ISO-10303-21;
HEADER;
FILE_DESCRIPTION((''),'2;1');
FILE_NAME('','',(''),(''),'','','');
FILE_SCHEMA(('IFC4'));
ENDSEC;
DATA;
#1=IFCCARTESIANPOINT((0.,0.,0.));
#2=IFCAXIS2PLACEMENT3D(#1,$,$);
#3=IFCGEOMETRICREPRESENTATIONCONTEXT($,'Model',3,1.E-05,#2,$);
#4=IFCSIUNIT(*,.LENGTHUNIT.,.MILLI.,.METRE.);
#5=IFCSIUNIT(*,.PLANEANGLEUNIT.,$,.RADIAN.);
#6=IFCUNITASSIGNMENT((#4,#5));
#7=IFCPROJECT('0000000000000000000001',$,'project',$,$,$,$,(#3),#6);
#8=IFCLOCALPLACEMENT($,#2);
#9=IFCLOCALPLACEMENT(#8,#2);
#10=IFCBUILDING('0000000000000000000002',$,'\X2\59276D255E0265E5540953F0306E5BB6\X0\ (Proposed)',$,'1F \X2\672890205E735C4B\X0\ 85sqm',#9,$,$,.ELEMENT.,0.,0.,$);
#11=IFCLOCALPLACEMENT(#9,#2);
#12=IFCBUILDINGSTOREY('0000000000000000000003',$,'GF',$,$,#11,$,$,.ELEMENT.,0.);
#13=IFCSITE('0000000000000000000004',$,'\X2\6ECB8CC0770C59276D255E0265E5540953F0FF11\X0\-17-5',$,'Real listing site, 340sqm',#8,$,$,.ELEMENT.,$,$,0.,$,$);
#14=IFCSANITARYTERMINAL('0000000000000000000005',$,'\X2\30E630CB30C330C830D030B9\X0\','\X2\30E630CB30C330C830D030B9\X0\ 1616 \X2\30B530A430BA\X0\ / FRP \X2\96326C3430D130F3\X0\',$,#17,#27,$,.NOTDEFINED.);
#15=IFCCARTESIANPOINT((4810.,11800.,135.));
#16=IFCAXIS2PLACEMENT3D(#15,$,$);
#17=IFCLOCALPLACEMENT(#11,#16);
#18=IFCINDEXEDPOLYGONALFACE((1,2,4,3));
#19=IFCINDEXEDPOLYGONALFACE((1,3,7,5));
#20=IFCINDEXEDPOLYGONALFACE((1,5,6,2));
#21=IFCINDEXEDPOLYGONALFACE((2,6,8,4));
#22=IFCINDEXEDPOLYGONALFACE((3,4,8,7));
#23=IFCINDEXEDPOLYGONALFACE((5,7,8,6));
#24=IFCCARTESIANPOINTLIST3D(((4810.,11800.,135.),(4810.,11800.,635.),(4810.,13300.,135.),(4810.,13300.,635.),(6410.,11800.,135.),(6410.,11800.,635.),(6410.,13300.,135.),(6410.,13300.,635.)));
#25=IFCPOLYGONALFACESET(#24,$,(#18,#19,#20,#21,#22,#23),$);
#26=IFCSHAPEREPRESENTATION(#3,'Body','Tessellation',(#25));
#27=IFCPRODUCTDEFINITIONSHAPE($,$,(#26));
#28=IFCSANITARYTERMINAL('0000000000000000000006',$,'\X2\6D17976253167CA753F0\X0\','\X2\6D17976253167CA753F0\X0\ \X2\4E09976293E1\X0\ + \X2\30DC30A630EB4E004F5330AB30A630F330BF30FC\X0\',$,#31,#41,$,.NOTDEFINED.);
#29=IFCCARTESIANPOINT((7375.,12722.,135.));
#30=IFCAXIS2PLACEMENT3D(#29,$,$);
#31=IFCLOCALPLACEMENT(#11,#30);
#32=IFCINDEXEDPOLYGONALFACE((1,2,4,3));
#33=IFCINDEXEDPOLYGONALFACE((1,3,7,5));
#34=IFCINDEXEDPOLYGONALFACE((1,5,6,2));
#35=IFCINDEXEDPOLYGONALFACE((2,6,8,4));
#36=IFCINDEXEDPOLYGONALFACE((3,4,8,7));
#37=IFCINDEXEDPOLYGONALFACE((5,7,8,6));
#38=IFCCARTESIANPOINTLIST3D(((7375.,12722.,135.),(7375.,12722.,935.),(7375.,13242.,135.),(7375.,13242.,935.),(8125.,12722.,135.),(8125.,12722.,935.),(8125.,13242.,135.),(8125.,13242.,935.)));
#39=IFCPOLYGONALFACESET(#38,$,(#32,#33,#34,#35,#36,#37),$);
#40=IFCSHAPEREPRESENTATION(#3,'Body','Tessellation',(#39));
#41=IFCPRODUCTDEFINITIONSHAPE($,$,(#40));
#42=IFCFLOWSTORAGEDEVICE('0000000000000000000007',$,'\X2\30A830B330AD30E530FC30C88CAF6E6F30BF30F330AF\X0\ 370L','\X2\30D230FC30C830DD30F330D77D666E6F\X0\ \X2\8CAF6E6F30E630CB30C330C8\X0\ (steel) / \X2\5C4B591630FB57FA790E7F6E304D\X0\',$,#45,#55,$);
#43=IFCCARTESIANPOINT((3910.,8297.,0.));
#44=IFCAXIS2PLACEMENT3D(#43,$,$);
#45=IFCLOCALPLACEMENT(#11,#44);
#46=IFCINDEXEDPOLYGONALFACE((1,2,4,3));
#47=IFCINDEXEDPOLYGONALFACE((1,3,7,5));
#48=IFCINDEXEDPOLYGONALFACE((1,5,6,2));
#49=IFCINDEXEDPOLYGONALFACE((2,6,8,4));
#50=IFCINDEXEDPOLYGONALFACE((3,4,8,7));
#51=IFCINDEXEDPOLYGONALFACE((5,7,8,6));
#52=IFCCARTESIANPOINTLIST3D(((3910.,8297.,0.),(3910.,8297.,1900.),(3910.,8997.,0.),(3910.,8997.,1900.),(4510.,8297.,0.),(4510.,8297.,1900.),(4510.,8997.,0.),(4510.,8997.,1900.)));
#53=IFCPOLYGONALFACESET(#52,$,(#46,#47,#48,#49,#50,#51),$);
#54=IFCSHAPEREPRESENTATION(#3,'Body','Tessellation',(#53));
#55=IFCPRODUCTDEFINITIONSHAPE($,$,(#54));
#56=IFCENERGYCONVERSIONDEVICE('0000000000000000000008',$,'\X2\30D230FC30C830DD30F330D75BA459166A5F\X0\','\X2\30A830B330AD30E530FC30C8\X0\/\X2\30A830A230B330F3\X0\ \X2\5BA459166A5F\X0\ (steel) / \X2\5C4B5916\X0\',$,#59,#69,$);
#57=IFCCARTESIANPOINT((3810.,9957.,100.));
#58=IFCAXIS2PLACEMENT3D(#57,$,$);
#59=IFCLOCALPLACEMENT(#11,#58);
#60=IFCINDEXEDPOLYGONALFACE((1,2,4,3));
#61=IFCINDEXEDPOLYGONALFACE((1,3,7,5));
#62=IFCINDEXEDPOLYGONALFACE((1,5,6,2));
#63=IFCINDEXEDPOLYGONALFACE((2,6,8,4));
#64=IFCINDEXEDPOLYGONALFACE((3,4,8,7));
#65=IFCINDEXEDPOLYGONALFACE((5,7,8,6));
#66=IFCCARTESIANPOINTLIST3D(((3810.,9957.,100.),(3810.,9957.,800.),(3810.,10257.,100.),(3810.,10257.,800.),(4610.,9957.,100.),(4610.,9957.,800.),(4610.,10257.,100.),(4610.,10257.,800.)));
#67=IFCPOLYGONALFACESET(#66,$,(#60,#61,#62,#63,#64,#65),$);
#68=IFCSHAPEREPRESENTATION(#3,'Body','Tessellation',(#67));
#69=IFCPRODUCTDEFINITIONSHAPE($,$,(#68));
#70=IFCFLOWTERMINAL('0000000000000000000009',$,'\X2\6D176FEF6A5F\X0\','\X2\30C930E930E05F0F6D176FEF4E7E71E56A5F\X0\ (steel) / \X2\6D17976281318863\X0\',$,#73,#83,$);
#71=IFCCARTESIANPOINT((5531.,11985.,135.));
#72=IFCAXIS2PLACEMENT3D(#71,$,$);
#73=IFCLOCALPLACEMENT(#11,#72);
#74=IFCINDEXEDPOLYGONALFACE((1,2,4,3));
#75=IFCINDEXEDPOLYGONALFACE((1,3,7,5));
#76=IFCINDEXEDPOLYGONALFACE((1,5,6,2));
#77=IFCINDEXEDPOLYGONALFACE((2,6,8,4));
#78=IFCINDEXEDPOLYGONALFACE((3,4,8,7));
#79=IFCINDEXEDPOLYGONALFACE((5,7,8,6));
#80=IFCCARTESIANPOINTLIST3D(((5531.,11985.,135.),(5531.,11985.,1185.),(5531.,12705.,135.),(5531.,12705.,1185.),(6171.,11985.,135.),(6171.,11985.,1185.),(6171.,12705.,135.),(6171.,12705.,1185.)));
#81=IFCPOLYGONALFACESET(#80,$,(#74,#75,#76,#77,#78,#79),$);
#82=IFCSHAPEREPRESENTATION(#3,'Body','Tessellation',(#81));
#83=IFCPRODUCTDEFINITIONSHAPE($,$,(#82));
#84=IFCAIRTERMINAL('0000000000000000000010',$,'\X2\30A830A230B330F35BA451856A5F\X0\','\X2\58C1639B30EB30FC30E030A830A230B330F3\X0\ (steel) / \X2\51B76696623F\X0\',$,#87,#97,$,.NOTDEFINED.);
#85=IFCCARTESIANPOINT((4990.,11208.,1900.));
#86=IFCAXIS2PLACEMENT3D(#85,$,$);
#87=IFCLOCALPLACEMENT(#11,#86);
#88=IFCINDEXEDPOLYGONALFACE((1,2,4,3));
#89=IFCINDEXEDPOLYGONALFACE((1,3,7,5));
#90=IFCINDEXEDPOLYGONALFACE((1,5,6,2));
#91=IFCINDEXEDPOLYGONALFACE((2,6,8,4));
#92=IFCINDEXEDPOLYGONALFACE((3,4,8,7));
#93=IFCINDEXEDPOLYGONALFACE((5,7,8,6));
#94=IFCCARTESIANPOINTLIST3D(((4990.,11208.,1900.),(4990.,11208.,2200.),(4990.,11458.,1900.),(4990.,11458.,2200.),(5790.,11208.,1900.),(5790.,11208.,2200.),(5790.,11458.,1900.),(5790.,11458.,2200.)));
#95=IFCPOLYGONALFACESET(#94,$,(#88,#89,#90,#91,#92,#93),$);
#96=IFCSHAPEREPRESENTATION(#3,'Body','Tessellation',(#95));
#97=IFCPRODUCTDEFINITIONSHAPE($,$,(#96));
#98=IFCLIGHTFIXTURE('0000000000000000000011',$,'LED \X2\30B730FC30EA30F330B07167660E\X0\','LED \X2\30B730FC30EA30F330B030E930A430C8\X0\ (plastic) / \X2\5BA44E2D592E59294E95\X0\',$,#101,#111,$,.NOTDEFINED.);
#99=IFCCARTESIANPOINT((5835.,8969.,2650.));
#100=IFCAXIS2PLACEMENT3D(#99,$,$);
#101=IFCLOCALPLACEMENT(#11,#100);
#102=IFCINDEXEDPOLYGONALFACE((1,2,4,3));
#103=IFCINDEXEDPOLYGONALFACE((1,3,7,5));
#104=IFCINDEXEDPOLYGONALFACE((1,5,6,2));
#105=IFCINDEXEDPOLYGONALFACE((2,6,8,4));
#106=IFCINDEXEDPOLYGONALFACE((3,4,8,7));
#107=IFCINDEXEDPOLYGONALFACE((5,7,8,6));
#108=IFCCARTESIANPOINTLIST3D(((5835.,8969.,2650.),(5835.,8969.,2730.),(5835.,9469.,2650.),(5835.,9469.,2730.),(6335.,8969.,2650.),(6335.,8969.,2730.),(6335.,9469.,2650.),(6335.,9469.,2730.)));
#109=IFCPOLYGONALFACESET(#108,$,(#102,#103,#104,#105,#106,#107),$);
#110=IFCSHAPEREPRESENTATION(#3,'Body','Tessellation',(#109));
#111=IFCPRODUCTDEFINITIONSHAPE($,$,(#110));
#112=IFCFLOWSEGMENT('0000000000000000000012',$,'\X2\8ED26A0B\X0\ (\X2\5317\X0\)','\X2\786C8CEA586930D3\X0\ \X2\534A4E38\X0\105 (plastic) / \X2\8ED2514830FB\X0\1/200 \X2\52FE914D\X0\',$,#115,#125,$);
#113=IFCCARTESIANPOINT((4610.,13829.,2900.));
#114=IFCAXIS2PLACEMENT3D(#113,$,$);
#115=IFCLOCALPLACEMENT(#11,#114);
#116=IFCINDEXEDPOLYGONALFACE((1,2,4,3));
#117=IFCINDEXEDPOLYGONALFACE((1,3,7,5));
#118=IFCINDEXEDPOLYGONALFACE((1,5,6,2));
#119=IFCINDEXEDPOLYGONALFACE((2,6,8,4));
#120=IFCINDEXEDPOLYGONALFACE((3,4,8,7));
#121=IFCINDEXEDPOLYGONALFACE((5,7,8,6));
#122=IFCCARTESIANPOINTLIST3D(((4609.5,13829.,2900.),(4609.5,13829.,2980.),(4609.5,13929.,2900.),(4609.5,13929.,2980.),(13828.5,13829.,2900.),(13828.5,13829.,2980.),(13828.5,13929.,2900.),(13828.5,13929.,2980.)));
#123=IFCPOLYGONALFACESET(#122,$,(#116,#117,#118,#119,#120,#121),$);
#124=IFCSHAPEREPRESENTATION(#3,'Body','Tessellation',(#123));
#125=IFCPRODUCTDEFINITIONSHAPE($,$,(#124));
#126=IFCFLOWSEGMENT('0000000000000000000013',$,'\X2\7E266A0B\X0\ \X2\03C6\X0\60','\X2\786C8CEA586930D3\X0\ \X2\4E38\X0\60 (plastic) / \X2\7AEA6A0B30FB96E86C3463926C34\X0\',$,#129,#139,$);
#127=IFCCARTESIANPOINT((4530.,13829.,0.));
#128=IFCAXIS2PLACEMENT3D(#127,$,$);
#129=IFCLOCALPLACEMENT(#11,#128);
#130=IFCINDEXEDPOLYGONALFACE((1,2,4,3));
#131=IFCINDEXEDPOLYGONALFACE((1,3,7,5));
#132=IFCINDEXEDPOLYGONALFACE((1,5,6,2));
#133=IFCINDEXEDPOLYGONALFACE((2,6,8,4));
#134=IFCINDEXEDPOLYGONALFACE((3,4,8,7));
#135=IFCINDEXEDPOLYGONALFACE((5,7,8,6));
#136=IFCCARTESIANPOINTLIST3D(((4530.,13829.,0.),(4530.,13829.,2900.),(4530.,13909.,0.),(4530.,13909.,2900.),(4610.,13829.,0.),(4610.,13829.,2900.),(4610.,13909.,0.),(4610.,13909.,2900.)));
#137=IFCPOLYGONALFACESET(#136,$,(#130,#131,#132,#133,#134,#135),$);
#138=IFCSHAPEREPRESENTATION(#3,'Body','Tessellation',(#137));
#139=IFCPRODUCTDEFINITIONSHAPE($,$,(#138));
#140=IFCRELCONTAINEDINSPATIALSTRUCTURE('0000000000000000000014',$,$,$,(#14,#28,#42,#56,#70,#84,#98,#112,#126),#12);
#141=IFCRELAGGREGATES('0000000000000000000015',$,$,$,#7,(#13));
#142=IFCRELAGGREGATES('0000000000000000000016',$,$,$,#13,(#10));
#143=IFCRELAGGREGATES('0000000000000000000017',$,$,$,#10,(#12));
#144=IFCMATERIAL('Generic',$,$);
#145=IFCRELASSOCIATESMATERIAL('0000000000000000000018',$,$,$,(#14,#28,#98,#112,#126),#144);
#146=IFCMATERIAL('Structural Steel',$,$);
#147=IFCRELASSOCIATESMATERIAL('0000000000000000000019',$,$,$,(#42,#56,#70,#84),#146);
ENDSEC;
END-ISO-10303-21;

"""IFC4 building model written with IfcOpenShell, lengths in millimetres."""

from ifc_helpers import new_model, si_unit, frame, frame_2d, origin, place, context, project, spatial, rectangle, extrude, material, element, save


model = new_model("IFC4")

# Units and contexts
model_context = context("Model", 3, precision=1e-05, world=origin())
ifc_project = project(units=[si_unit("LENGTHUNIT", "METRE", prefix="MILLI"), si_unit("PLANEANGLEUNIT", "RADIAN")], contexts=[model_context])

# Site, building, storey
site_placement = place(None, origin())
site = spatial("IfcSite", under=ifc_project, at=site_placement, Name="滋賀県大津市日吉台１-17-5", ObjectType="Real listing site, 340sqm", CompositionType="ELEMENT", RefElevation=0.0)
building_placement = place(site_placement, origin())
building = spatial("IfcBuilding", under=site, at=building_placement, Name="大津市日吉台の家 (Proposed)", ObjectType="1F 木造平屋 85sqm", CompositionType="ELEMENT", ElevationOfRefHeight=0.0, ElevationOfTerrain=0.0)
storey_placement = place(building_placement, origin())
storey = spatial("IfcBuildingStorey", under=building, at=storey_placement, Name="GF", CompositionType="ELEMENT", Elevation=0.0)

# Shared definitions
ifc_material_1 = material(Name="Structural Steel")

# Shared definitions
ifc_material_2 = material(Name="Generic")

# Sanitary terminals
sanitary_terminal_1_placement = place(storey_placement, frame((4810.0, 11800.0, 135.0)))
element("IfcSanitaryTerminal", 1, at=sanitary_terminal_1_placement, inside=storey, material=ifc_material_2, Name="ユニットバス", Description="ユニットバス 1616 サイズ / FRP 防水パン", PredefinedType="NOTDEFINED", context=model_context, shape_type="SweptSolid", body=[
    extrude(rectangle(XDim=1600.0, YDim=1500.0, at=frame_2d((800.0, 750.0))), frame((4810.0, 11800.0, 135.0)), (0.0, 0.0, 1.0), 500.0),
])
sanitary_terminal_2_placement = place(storey_placement, frame((7375.0, 12722.0, 135.0)))
element("IfcSanitaryTerminal", 2, at=sanitary_terminal_2_placement, inside=storey, material=ifc_material_2, Name="洗面化粧台", Description="洗面化粧台 三面鏡 + ボウル一体カウンター", PredefinedType="NOTDEFINED", context=model_context, shape_type="SweptSolid", body=[
    extrude(rectangle(XDim=750.0, YDim=520.0, at=frame_2d((375.0, 260.0))), frame((7375.0, 12722.0, 135.0)), (0.0, 0.0, 1.0), 800.0),
])

# Flow storage device
flow_storage_device_placement = place(storey_placement, frame((3910.0, 8297.0, 0.0)))
element("IfcFlowStorageDevice", 3, at=flow_storage_device_placement, inside=storey, material=ifc_material_1, Name="エコキュート貯湯タンク 370L", Description="ヒートポンプ給湯 貯湯ユニット (steel) / 屋外・基礎置き", context=model_context, shape_type="SweptSolid", body=[
    extrude(rectangle(XDim=600.0, YDim=700.0, at=frame_2d((300.0, 350.0))), frame((3910.0, 8297.0, 0.0)), (0.0, 0.0, 1.0), 1900.0),
])

# Energy conversion device
energy_conversion_device_placement = place(storey_placement, frame((3810.0, 9957.0, 100.0)))
element("IfcEnergyConversionDevice", 4, at=energy_conversion_device_placement, inside=storey, material=ifc_material_1, Name="ヒートポンプ室外機", Description="エコキュート/エアコン 室外機 (steel) / 屋外", context=model_context, shape_type="SweptSolid", body=[
    extrude(rectangle(XDim=800.0, YDim=300.0, at=frame_2d((400.0, 150.0))), frame((3810.0, 9957.0, 100.0)), (0.0, 0.0, 1.0), 700.0),
])

# Flow terminal
flow_terminal_placement = place(storey_placement, frame((5531.0, 11985.0, 135.0)))
element("IfcFlowTerminal", 5, at=flow_terminal_placement, inside=storey, material=ifc_material_1, Name="洗濯機", Description="ドラム式洗濯乾燥機 (steel) / 洗面脱衣", context=model_context, shape_type="SweptSolid", body=[
    extrude(rectangle(XDim=640.0, YDim=720.0, at=frame_2d((320.0, 360.0))), frame((5531.0, 11985.0, 135.0)), (0.0, 0.0, 1.0), 1050.0),
])

# Air terminal
air_terminal_placement = place(storey_placement, frame((4990.0, 11208.0, 1900.0)))
element("IfcAirTerminal", 6, at=air_terminal_placement, inside=storey, material=ifc_material_1, Name="エアコン室内機", Description="壁掛ルームエアコン (steel) / 冷暖房", PredefinedType="NOTDEFINED", context=model_context, shape_type="SweptSolid", body=[
    extrude(rectangle(XDim=800.0, YDim=250.0, at=frame_2d((400.0, 125.0))), frame((4990.0, 11208.0, 1900.0)), (0.0, 0.0, 1.0), 300.0),
])

# Light fixture
light_fixture_placement = place(storey_placement, frame((5835.0, 8969.0, 2650.0)))
element("IfcLightFixture", 7, at=light_fixture_placement, inside=storey, material=ifc_material_2, Name="LED シーリング照明", Description="LED シーリングライト (plastic) / 室中央天井", PredefinedType="NOTDEFINED", context=model_context, shape_type="SweptSolid", body=[
    extrude(rectangle(XDim=500.0, YDim=500.0, at=frame_2d((250.0, 250.0))), frame((5835.0, 8969.0, 2650.0)), (0.0, 0.0, 1.0), 80.0),
])

# Flow segments
flow_segment_1_placement = place(storey_placement, frame((4610.0, 13829.0, 2900.0)))
element("IfcFlowSegment", 8, at=flow_segment_1_placement, inside=storey, material=ifc_material_2, Name="軒樋 (北)", Description="硬質塩ビ 半丸105 (plastic) / 軒先・1/200 勾配", context=model_context, shape_type="SweptSolid", body=[
    extrude(rectangle(XDim=9219.0, YDim=100.0, at=frame_2d((4609.0, 50.0))), frame((4610.0, 13829.0, 2900.0)), (0.0, 0.0, 1.0), 80.0),
])
flow_segment_2_placement = place(storey_placement, frame((4530.0, 13829.0, 0.0)))
element("IfcFlowSegment", 9, at=flow_segment_2_placement, inside=storey, material=ifc_material_2, Name="縦樋 φ60", Description="硬質塩ビ 丸60 (plastic) / 竪樋・雨水排水", context=model_context, shape_type="SweptSolid", body=[
    extrude(rectangle(XDim=80.0, YDim=80.0, at=frame_2d((40.0, 40.0))), frame((4530.0, 13829.0, 0.0)), (0.0, 0.0, 1.0), 2900.0),
])

save(model, "model.ifc")
